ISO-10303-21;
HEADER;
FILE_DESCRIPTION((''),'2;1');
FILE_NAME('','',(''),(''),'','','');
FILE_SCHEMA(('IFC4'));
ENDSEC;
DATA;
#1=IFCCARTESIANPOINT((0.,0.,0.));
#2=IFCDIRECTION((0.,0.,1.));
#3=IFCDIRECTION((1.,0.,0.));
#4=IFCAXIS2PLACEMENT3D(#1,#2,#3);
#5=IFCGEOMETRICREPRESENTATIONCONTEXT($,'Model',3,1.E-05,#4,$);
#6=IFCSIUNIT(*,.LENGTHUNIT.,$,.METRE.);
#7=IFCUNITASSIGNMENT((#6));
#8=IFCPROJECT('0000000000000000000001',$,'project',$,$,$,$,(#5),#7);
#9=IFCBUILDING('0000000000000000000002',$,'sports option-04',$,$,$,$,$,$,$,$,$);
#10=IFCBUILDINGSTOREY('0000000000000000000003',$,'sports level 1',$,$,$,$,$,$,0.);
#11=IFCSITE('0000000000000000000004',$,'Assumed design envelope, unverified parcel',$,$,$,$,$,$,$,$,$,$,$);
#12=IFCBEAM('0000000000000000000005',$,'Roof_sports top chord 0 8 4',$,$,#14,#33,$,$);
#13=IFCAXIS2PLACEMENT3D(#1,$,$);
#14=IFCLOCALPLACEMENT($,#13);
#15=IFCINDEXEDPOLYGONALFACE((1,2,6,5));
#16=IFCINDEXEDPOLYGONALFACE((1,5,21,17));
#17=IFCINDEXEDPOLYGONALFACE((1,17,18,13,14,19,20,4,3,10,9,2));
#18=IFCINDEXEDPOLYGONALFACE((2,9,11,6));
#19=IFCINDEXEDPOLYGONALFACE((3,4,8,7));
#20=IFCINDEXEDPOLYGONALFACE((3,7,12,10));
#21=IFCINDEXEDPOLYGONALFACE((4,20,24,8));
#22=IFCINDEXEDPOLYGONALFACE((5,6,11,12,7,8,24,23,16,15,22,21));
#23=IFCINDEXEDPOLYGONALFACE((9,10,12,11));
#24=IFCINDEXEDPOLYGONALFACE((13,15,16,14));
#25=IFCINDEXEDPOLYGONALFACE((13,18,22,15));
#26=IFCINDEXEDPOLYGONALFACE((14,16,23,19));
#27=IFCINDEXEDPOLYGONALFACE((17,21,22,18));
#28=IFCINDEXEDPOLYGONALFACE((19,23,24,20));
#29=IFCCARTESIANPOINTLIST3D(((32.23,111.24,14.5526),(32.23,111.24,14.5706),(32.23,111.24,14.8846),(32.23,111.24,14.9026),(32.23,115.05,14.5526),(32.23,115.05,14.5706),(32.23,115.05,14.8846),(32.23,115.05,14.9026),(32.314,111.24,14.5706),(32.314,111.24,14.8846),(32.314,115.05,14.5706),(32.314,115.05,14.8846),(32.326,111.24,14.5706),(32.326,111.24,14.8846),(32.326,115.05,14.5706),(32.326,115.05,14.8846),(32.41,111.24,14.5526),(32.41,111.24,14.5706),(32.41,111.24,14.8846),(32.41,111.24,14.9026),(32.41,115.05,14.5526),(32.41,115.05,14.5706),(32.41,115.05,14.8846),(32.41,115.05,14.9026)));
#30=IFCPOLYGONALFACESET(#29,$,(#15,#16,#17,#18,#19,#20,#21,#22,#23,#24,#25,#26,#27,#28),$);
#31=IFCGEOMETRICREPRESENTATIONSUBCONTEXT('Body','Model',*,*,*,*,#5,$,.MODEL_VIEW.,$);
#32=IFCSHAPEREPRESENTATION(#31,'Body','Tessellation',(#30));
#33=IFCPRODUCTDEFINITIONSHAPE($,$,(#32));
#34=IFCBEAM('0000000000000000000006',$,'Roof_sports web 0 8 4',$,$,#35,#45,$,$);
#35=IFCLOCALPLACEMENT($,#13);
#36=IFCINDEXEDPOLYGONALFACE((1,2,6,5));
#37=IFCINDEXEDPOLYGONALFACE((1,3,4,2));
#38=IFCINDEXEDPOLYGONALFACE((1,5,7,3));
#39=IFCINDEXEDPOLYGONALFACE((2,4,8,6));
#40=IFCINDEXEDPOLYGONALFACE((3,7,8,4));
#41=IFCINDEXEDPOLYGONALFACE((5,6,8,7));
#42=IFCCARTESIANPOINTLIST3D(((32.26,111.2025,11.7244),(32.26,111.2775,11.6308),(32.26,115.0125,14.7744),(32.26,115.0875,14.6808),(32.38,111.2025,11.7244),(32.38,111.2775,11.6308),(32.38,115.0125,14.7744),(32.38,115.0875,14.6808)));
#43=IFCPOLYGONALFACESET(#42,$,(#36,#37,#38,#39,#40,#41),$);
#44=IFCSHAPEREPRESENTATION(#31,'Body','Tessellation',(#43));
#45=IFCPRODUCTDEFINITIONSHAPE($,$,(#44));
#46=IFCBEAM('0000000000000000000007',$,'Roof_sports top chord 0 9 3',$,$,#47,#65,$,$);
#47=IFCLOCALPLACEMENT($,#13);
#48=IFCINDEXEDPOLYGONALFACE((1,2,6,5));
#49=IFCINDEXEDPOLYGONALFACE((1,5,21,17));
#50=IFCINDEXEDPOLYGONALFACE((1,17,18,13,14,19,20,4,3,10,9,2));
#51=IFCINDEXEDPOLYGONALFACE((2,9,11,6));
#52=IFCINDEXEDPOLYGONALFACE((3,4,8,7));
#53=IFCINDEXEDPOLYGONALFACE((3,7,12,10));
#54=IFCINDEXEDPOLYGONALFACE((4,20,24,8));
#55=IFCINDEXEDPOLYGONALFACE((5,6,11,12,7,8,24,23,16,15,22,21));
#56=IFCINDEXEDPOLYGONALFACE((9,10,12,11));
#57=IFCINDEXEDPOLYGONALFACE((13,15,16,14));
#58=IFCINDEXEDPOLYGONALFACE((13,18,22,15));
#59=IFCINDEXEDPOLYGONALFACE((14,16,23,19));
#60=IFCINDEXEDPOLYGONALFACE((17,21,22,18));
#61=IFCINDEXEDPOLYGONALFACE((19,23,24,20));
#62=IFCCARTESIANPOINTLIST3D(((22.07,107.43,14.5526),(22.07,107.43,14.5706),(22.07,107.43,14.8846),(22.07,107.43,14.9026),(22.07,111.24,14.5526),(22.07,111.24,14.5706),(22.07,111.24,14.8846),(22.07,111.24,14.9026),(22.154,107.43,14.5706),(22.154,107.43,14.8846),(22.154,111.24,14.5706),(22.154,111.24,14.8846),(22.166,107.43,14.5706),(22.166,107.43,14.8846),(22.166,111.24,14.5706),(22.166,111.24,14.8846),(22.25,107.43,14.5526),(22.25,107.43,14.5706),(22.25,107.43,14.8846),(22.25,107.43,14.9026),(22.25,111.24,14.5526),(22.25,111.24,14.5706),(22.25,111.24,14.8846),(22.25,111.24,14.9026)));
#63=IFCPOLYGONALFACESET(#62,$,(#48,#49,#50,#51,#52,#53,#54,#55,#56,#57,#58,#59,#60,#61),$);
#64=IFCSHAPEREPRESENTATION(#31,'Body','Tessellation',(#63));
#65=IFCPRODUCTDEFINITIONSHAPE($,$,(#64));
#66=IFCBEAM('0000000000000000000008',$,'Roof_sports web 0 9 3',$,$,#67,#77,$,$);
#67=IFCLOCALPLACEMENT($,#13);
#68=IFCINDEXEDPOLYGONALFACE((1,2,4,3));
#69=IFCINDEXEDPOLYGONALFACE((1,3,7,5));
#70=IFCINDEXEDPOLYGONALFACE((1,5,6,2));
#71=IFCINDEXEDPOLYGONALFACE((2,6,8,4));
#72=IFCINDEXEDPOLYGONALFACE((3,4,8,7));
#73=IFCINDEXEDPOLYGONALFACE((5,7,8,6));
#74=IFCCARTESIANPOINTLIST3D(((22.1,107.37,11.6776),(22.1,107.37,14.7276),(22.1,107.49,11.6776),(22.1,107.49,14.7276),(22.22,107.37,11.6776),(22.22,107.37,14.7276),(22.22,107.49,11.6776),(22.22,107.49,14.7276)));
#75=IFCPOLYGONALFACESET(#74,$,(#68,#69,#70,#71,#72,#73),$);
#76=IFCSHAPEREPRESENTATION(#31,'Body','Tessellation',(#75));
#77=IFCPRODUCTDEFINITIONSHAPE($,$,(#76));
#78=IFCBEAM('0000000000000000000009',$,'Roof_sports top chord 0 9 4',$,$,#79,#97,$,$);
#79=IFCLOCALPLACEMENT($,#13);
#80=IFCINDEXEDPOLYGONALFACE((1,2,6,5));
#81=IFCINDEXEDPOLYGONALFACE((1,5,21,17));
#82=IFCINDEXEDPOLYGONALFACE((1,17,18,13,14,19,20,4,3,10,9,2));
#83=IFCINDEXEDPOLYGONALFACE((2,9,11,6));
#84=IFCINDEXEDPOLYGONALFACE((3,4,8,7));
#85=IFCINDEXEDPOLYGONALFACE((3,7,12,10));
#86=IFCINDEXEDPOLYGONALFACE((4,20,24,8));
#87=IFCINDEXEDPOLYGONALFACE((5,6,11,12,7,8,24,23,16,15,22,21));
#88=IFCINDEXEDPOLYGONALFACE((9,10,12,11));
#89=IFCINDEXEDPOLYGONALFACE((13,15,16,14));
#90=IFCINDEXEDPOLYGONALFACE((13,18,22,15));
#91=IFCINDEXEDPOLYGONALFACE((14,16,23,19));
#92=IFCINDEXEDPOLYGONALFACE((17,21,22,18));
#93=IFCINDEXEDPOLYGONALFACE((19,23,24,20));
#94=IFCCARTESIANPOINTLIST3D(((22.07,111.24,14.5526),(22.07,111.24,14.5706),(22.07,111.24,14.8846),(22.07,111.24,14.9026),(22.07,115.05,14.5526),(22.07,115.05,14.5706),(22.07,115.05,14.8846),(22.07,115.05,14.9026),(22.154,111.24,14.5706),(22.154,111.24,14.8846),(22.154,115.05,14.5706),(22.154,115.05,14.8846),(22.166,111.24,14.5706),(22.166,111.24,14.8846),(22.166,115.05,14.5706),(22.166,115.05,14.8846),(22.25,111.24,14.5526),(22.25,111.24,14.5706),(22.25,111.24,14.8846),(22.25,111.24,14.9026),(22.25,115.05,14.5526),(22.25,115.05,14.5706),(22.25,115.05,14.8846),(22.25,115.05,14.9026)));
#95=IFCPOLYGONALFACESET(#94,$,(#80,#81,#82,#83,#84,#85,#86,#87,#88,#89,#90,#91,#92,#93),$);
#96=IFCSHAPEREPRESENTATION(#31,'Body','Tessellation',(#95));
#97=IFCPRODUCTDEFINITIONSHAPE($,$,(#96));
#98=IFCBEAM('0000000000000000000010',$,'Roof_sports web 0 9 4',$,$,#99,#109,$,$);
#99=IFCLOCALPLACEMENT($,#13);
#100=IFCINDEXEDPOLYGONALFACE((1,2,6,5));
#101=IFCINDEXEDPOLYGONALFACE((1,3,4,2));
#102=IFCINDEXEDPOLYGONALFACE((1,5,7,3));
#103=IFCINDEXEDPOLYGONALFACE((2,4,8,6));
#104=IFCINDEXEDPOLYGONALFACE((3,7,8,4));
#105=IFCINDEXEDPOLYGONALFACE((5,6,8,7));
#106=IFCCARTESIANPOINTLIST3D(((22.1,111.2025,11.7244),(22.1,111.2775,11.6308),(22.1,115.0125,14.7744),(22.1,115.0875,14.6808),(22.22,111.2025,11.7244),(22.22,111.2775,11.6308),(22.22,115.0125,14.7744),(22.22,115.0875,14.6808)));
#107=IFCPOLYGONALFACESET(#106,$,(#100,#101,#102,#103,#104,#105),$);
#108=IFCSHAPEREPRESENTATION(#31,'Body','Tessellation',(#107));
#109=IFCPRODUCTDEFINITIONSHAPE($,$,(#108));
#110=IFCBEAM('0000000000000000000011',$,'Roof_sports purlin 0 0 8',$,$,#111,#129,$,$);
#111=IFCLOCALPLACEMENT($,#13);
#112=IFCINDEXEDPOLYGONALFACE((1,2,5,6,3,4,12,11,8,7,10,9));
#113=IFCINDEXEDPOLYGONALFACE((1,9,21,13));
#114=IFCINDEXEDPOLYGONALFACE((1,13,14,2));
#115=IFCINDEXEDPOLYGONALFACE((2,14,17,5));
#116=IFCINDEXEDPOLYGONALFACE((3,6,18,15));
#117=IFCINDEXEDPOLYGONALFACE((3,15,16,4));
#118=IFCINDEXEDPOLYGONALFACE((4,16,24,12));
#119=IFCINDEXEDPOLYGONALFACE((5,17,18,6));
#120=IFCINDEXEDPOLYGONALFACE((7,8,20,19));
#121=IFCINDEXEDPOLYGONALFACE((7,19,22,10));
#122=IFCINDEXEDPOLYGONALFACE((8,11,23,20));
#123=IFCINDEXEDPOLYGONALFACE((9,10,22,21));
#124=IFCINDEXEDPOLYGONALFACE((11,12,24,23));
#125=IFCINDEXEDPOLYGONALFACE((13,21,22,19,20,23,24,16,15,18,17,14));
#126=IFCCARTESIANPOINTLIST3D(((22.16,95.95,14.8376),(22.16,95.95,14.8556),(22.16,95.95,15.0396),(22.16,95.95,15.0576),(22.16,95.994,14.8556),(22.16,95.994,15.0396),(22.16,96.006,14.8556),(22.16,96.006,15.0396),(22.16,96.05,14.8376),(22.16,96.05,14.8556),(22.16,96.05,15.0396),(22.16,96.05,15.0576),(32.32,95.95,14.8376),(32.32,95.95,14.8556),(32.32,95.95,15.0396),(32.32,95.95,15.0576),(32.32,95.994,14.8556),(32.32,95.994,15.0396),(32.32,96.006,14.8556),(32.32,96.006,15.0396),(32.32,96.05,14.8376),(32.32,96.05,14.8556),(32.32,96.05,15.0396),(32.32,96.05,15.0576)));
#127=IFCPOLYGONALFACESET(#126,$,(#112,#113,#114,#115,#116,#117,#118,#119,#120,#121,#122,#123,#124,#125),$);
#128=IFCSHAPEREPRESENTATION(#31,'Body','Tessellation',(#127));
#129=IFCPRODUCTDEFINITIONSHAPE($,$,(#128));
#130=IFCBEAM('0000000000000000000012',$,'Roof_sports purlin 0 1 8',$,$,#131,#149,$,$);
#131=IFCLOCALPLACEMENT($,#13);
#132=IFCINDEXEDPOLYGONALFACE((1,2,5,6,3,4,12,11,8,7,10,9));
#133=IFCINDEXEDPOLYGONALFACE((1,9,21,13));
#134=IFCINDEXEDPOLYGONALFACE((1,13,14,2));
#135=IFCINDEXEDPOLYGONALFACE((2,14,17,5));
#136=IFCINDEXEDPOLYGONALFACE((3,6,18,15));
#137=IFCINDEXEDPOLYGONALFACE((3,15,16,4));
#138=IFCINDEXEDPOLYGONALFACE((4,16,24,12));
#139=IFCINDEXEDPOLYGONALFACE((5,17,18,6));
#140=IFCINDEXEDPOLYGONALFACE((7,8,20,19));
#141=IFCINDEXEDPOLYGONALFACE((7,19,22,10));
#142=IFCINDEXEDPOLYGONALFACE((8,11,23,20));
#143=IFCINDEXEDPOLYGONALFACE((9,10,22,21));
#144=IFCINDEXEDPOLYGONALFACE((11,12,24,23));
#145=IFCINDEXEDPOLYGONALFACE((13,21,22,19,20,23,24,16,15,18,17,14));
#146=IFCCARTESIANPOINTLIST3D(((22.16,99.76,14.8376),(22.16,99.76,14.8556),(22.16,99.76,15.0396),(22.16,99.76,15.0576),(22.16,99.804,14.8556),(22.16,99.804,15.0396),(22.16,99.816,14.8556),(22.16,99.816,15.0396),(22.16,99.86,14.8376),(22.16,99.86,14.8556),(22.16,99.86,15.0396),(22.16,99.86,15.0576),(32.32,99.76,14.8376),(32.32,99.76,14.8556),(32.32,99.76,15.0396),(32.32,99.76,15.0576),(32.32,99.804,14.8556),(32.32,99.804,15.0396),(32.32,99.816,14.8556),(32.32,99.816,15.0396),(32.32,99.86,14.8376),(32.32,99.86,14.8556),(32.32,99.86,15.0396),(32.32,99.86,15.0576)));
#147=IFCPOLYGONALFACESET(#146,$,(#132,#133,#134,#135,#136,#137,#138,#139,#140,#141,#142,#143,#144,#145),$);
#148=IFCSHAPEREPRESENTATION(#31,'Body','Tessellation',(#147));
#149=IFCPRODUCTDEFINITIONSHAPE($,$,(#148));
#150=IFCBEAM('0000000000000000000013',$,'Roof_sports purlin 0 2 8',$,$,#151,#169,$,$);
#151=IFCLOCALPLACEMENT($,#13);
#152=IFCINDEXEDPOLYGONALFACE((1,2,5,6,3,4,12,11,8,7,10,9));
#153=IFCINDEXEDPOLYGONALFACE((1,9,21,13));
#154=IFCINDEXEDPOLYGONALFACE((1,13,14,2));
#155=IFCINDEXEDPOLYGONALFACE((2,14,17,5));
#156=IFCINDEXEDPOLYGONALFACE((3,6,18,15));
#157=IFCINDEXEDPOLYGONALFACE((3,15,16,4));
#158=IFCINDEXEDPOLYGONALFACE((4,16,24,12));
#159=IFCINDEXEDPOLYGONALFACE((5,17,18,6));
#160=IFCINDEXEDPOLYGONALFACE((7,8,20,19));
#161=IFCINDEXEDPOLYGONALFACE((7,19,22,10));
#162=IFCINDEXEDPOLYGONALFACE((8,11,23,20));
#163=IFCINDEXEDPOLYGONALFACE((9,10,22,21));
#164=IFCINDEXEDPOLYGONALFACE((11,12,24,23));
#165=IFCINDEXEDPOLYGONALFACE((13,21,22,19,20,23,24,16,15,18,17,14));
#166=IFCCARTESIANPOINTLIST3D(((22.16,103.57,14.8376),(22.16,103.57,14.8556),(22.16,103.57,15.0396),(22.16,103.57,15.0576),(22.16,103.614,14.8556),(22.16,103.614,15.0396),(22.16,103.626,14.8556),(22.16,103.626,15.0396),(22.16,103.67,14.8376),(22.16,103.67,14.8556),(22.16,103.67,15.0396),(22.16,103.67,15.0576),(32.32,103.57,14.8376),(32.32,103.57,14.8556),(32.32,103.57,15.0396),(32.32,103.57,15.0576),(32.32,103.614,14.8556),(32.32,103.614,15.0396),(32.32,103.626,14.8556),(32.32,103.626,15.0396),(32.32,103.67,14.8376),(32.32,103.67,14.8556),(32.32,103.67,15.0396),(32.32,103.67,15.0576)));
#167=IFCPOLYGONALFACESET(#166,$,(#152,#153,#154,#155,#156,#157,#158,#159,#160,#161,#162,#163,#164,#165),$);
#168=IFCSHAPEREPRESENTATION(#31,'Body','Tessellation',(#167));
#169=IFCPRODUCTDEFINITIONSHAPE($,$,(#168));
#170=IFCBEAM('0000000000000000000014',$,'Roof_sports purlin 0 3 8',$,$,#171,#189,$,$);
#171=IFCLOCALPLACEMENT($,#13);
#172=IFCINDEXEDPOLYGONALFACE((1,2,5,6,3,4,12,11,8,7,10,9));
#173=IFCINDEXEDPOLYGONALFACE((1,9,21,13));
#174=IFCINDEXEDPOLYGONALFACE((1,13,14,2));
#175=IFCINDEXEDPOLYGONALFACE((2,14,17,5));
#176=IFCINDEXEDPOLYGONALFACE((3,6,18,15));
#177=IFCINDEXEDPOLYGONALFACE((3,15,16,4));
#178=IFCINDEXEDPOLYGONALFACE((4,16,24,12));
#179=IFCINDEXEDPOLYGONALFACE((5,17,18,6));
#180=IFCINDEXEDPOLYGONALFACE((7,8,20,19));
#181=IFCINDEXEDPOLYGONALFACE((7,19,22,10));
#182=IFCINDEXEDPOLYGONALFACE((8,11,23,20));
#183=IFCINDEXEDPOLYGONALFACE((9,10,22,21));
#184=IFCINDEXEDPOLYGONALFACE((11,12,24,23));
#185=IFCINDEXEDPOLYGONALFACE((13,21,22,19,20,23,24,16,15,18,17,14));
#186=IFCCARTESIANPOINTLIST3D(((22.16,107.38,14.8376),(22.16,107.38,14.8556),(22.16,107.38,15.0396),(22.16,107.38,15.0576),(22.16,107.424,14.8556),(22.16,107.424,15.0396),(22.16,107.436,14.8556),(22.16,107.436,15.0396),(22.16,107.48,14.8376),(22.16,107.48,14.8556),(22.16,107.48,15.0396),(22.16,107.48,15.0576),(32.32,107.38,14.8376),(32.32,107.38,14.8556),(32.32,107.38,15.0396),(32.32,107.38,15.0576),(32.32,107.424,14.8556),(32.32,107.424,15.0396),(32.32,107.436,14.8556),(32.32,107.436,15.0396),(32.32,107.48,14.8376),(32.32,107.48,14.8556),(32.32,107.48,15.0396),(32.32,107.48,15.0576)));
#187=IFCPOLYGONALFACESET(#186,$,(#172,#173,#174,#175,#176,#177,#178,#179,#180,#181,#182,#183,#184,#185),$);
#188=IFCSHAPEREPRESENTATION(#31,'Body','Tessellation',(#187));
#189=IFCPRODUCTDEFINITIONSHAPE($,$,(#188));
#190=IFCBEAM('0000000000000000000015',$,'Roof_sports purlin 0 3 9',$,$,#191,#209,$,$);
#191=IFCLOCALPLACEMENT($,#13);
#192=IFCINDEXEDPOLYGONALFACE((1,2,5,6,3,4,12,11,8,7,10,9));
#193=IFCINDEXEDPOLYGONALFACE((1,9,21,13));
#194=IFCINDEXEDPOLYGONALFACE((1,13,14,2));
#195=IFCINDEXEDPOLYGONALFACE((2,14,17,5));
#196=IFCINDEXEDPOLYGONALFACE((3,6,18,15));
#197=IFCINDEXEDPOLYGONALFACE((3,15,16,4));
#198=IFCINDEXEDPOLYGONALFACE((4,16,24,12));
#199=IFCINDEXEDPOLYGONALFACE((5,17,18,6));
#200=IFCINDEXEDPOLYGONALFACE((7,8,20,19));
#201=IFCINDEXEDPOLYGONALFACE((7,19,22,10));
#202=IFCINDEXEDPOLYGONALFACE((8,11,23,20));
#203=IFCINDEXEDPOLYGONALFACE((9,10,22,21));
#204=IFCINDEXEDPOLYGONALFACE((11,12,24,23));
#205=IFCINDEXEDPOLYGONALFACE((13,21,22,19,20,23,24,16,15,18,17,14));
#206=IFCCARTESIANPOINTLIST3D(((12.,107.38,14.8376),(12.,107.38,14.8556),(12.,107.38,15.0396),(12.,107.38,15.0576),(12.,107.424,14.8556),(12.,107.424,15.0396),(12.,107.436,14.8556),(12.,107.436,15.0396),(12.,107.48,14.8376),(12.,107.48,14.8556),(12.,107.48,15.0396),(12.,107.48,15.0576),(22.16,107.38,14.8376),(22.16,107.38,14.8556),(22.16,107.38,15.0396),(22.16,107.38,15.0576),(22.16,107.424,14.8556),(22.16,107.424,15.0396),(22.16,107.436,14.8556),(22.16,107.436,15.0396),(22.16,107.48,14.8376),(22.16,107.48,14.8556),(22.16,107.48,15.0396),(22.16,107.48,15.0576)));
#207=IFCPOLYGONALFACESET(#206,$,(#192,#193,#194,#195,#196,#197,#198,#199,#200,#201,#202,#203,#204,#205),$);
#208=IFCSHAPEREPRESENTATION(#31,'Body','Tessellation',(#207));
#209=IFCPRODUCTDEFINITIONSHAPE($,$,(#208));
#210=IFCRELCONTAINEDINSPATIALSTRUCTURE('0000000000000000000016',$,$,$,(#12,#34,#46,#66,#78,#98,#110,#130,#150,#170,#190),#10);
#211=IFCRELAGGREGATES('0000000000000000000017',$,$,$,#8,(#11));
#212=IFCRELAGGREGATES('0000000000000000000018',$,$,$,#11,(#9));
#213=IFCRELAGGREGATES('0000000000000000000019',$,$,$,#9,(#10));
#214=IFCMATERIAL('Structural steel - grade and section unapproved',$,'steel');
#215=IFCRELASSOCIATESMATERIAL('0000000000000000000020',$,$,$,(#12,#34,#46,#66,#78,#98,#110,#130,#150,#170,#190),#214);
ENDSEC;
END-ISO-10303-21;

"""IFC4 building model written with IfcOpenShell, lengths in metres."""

from ifc_helpers import new_model, si_unit, frame, origin_with_axes, place, context, subcontext, project, spatial, rectangle, i_section, extrude, material, element, save


model = new_model("IFC4")

# Units and contexts
model_context = context("Model", 3, precision=1e-05, world=origin_with_axes())
body_context = subcontext(model_context, "Body", "Model", "MODEL_VIEW")
ifc_project = project(units=[si_unit("LENGTHUNIT", "METRE")], contexts=[model_context])

# Site, building, storey
site = spatial("IfcSite", under=ifc_project, Name="Assumed design envelope, unverified parcel")
building = spatial("IfcBuilding", under=site, Name="sports option-04")
storey = spatial("IfcBuildingStorey", under=building, Name="sports level 1", Elevation=0.0)

# Shared definitions
ifc_material_1 = material(Name="Structural steel - grade and section unapproved", Category="steel")

# Beams
beam_1_placement = place(None, frame((32.32, 111.24, 14.7276), z_axis=(0.0, 1.0, 0.0), x_axis=(-1.0, 0.0, 0.0)))
element("IfcBeam", 1, at=beam_1_placement, inside=storey, material=ifc_material_1, Name="Roof_sports top chord 0 8 4", context=body_context, shape_type="SweptSolid", body=[
    extrude(i_section(OverallWidth=0.18, OverallDepth=0.35, WebThickness=0.012, FlangeThickness=0.018, FilletRadius=0.0), origin_with_axes(), (0.0, 0.0, 1.0), 3.81),
])
beam_2_placement = place(None, frame((32.32, 111.24, 11.6776), z_axis=(0.0, 0.780669, 0.624944), x_axis=(-1.0, 0.0, 0.0)))
element("IfcBeam", 2, at=beam_2_placement, inside=storey, material=ifc_material_1, Name="Roof_sports web 0 8 4", context=body_context, shape_type="SweptSolid", body=[
    extrude(rectangle(XDim=0.12, YDim=0.12), origin_with_axes(), (0.0, 0.0, 1.0), 4.8804),
])
beam_3_placement = place(None, frame((22.16, 107.43, 14.7276), z_axis=(0.0, 1.0, 0.0), x_axis=(-1.0, 0.0, 0.0)))
element("IfcBeam", 3, at=beam_3_placement, inside=storey, material=ifc_material_1, Name="Roof_sports top chord 0 9 3", context=body_context, shape_type="SweptSolid", body=[
    extrude(i_section(OverallWidth=0.18, OverallDepth=0.35, WebThickness=0.012, FlangeThickness=0.018, FilletRadius=0.0), origin_with_axes(), (0.0, 0.0, 1.0), 3.81),
])
beam_4_placement = place(None, frame((22.16, 107.43, 11.6776), z_axis=(0.0, 0.0, 1.0), x_axis=(-1.0, 0.0, 0.0)))
element("IfcBeam", 4, at=beam_4_placement, inside=storey, material=ifc_material_1, Name="Roof_sports web 0 9 3", context=body_context, shape_type="SweptSolid", body=[
    extrude(rectangle(XDim=0.12, YDim=0.12), origin_with_axes(), (0.0, 0.0, 1.0), 3.05),
])
beam_5_placement = place(None, frame((22.16, 111.24, 14.7276), z_axis=(0.0, 1.0, 0.0), x_axis=(-1.0, 0.0, 0.0)))
element("IfcBeam", 5, at=beam_5_placement, inside=storey, material=ifc_material_1, Name="Roof_sports top chord 0 9 4", context=body_context, shape_type="SweptSolid", body=[
    extrude(i_section(OverallWidth=0.18, OverallDepth=0.35, WebThickness=0.012, FlangeThickness=0.018, FilletRadius=0.0), origin_with_axes(), (0.0, 0.0, 1.0), 3.81),
])
beam_6_placement = place(None, frame((22.16, 111.24, 11.6776), z_axis=(0.0, 0.780669, 0.624944), x_axis=(-1.0, 0.0, 0.0)))
element("IfcBeam", 6, at=beam_6_placement, inside=storey, material=ifc_material_1, Name="Roof_sports web 0 9 4", context=body_context, shape_type="SweptSolid", body=[
    extrude(rectangle(XDim=0.12, YDim=0.12), origin_with_axes(), (0.0, 0.0, 1.0), 4.8804),
])
for number, where, z_axis, x_axis, name in (
    (7, (32.32, 96.0, 14.9476), (-1.0, 0.0, 0.0), (0.0, -1.0, 0.0), "Roof_sports purlin 0 0 8"),
    (8, (32.32, 99.81, 14.9476), (-1.0, 0.0, 0.0), (0.0, -1.0, 0.0), "Roof_sports purlin 0 1 8"),
    (9, (32.32, 103.62, 14.9476), (-1.0, 0.0, 0.0), (0.0, -1.0, 0.0), "Roof_sports purlin 0 2 8"),
    (10, (32.32, 107.43, 14.9476), (-1.0, 0.0, 0.0), (0.0, -1.0, 0.0), "Roof_sports purlin 0 3 8"),
    (11, (22.16, 107.43, 14.9476), (-1.0, 0.0, 0.0), (0.0, -1.0, 0.0), "Roof_sports purlin 0 3 9"),
):
    element("IfcBeam", number, at=place(None, frame(where, z_axis=z_axis, x_axis=x_axis)), inside=storey, material=ifc_material_1, Name=name, context=body_context, shape_type="SweptSolid", body=[
        extrude(i_section(OverallWidth=0.1, OverallDepth=0.22, WebThickness=0.012, FlangeThickness=0.018, FilletRadius=0.0), origin_with_axes(), (0.0, 0.0, 1.0), 10.16),
    ])

save(model, "model.ifc")
